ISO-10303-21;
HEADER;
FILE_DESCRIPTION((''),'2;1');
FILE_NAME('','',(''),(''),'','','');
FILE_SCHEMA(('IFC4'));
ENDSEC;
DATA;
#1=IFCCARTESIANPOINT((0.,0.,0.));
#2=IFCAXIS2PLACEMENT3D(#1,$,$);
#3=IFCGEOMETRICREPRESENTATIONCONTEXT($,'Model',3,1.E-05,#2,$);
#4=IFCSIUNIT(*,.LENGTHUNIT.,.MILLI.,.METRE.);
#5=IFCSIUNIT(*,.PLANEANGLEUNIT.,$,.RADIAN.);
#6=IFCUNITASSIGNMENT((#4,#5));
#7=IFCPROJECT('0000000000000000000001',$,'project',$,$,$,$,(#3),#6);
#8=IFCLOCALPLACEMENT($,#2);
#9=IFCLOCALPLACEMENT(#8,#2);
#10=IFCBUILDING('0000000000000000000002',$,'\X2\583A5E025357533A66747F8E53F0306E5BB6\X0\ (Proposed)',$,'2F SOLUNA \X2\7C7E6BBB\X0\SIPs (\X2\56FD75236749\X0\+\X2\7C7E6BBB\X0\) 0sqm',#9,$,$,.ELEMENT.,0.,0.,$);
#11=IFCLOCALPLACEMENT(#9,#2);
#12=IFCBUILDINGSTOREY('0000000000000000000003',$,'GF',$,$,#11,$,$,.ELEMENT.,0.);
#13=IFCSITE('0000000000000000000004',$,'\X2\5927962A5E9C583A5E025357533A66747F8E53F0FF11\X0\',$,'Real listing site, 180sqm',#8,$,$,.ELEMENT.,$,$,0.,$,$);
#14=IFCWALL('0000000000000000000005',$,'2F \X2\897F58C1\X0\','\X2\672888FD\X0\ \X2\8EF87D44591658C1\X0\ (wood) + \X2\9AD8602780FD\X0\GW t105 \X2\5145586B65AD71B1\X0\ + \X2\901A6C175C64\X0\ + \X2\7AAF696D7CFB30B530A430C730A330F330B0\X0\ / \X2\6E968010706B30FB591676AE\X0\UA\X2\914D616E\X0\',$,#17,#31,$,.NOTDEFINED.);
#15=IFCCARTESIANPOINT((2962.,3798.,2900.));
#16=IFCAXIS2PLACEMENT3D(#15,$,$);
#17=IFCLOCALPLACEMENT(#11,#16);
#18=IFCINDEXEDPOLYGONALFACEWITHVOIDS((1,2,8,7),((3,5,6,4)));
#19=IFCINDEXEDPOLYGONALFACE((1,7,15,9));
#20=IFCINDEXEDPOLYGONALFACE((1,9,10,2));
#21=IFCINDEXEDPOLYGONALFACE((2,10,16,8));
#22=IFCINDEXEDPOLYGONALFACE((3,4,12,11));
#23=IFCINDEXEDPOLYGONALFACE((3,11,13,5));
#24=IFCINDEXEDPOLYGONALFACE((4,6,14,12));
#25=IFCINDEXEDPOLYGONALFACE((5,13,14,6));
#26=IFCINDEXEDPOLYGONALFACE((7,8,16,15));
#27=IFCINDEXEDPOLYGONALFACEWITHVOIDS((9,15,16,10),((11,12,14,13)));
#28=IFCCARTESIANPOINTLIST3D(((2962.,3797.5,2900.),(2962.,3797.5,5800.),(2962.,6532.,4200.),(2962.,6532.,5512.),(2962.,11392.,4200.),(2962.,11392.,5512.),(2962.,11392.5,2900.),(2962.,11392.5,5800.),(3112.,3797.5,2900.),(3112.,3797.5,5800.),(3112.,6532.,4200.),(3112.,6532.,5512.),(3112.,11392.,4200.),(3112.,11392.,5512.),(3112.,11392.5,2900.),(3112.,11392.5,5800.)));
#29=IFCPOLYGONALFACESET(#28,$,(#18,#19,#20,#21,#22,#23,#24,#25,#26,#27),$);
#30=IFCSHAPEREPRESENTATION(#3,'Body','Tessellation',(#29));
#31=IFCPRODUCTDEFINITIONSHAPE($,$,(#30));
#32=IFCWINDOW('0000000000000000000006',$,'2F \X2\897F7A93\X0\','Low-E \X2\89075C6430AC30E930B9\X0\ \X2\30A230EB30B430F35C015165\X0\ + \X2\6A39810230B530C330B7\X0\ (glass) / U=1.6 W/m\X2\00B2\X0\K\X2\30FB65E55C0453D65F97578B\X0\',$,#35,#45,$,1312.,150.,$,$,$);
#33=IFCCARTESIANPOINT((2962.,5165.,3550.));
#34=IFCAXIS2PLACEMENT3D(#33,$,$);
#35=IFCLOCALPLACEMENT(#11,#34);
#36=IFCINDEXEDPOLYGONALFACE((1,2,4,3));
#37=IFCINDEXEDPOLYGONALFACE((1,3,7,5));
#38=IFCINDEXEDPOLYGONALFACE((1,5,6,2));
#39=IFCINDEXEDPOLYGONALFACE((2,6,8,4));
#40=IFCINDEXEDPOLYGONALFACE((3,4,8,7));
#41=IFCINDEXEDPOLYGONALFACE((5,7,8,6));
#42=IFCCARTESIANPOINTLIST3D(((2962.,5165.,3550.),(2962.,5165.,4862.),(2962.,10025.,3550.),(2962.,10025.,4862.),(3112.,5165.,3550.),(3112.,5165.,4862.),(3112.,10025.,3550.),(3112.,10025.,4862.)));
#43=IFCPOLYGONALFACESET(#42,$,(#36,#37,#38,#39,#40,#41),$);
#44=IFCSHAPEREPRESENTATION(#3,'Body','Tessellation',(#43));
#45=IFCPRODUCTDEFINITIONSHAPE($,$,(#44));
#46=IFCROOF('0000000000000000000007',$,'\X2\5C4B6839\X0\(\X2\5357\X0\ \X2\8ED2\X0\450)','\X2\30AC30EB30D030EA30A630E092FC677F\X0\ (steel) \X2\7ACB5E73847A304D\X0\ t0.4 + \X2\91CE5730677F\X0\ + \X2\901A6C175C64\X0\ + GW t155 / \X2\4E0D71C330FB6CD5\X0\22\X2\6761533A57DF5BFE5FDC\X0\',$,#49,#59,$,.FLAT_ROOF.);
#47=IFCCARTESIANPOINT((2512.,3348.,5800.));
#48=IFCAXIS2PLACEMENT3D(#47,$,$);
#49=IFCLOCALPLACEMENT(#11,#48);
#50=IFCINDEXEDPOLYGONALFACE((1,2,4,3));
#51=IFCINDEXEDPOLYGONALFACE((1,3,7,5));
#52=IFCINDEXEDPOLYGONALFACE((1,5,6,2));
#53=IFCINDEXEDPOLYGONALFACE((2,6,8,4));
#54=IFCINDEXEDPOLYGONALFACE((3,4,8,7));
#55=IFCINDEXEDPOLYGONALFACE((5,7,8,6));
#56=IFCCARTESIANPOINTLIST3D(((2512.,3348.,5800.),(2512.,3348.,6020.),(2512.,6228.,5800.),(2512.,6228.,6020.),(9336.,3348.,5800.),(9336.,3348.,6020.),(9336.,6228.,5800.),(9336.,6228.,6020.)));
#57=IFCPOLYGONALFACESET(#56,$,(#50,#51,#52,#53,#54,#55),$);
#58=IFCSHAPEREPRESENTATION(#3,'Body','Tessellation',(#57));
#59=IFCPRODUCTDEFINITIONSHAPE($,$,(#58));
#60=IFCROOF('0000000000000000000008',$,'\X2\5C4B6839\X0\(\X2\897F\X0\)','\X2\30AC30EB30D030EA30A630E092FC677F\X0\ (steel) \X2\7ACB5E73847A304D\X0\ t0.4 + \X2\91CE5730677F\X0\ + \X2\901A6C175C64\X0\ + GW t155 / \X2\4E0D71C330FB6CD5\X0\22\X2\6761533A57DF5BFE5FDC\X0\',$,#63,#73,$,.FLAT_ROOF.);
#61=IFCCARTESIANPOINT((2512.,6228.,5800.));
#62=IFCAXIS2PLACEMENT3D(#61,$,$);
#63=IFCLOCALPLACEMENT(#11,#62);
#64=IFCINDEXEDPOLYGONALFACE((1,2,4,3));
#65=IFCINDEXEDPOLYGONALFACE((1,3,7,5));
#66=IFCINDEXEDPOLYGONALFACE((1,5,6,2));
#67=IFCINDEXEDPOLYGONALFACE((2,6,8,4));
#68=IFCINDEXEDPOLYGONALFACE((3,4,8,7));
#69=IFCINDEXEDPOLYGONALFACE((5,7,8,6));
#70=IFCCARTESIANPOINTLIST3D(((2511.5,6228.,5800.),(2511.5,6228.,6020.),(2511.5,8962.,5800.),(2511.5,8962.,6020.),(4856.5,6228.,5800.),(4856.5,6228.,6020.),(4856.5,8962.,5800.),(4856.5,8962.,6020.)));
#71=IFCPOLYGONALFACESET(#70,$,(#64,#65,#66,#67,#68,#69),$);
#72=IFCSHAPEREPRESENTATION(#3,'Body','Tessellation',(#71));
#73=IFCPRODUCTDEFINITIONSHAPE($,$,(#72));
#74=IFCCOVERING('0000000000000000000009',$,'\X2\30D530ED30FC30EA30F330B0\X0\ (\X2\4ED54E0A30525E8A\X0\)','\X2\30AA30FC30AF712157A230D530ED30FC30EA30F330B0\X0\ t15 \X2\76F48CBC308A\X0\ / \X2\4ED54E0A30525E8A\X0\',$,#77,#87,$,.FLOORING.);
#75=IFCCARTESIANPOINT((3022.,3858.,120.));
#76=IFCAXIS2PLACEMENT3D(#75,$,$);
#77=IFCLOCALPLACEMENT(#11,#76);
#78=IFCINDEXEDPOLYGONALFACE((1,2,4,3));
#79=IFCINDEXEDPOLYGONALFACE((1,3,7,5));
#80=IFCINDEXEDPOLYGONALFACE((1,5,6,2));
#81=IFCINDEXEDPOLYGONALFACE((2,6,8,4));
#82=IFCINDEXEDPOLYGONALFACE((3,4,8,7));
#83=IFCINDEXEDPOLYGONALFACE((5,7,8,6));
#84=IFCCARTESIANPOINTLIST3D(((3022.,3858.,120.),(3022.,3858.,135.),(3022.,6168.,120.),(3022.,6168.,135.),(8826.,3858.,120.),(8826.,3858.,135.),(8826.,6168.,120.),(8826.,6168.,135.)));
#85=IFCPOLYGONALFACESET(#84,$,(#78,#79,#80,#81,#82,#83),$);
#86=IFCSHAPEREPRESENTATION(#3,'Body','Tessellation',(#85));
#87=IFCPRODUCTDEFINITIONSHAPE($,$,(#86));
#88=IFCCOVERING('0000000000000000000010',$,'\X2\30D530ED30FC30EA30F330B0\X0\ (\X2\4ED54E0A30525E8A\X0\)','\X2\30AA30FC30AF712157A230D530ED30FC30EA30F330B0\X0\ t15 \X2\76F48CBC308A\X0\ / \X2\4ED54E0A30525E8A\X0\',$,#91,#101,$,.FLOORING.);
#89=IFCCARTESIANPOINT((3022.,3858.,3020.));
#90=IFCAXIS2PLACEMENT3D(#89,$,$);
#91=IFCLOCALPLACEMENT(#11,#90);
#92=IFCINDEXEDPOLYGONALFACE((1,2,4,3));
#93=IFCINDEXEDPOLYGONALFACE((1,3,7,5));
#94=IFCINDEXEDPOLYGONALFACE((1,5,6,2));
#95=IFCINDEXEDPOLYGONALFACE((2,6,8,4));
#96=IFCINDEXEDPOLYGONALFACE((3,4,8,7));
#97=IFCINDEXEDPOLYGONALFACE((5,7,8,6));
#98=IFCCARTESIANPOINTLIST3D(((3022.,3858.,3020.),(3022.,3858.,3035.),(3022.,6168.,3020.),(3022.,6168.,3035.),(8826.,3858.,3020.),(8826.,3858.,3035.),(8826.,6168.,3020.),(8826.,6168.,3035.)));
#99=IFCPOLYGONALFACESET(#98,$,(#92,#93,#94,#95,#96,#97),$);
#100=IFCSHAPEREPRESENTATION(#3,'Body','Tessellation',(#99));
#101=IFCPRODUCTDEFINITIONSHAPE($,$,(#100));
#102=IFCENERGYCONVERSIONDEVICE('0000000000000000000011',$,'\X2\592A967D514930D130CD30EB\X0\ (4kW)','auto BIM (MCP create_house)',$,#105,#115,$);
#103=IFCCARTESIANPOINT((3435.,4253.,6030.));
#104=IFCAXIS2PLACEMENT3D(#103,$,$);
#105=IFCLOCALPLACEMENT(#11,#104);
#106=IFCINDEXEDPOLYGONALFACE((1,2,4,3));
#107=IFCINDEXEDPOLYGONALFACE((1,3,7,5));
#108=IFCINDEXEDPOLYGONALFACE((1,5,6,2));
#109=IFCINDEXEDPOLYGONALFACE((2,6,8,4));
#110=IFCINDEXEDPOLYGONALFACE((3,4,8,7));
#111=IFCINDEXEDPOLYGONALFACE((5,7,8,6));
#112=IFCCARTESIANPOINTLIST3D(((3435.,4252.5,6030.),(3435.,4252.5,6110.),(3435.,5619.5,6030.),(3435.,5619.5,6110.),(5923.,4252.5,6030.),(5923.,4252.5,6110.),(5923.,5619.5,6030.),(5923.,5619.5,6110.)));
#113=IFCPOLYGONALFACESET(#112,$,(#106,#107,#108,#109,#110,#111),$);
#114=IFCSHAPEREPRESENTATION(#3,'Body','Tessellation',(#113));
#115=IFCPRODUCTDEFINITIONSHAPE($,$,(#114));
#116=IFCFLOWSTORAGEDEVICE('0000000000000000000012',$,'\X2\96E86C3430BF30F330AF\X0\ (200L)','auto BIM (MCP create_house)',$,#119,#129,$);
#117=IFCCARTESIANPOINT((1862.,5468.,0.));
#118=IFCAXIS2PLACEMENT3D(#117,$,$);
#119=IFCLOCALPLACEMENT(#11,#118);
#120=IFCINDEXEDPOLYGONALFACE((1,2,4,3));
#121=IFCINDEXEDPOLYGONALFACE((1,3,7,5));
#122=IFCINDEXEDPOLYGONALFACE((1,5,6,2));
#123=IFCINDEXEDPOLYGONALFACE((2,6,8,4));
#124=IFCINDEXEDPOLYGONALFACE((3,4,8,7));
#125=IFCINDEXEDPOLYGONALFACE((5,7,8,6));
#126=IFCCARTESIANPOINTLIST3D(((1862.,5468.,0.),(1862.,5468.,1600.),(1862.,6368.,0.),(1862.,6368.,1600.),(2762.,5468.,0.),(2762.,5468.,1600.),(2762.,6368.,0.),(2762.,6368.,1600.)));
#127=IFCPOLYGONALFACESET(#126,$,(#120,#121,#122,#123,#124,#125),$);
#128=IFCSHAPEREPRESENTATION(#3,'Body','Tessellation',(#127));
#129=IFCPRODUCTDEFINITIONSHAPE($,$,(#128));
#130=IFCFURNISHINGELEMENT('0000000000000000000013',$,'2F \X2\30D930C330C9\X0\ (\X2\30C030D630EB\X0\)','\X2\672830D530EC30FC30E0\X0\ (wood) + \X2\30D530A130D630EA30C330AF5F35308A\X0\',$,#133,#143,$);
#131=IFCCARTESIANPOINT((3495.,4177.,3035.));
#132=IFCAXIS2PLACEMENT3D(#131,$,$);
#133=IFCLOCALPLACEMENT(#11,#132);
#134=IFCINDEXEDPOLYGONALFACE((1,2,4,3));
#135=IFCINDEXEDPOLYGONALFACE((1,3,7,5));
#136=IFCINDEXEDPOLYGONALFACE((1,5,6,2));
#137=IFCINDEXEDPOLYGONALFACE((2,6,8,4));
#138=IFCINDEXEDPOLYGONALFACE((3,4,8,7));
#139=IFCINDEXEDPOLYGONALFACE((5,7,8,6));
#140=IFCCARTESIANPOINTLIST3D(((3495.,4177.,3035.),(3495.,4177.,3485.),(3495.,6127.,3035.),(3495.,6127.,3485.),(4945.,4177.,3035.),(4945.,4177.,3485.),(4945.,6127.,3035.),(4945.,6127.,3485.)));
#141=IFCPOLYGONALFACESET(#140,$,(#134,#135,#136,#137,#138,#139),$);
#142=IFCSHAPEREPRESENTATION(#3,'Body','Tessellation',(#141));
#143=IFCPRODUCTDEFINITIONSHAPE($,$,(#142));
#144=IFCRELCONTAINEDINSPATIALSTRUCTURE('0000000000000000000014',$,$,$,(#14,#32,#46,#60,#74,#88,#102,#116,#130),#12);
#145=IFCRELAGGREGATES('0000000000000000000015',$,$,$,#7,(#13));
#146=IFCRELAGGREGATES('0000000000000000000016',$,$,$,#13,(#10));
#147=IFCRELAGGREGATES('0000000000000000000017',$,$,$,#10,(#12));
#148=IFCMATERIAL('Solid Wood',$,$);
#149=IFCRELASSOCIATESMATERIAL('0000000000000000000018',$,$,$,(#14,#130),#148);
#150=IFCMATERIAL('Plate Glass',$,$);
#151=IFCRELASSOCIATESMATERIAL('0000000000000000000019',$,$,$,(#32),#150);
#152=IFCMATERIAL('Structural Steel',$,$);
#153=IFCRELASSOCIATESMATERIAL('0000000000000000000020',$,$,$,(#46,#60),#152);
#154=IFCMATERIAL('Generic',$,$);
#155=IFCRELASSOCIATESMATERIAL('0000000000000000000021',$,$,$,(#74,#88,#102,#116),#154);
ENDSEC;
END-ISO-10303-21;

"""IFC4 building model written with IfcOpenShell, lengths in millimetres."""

from ifc_helpers import new_model, si_unit, frame, frame_2d, origin, place, context, project, spatial, rectangle, extrude, material, element, fill, save


model = new_model("IFC4")

# Units and contexts
model_context = context("Model", 3, precision=1e-05, world=origin())
ifc_project = project(units=[si_unit("LENGTHUNIT", "METRE", prefix="MILLI"), si_unit("PLANEANGLEUNIT", "RADIAN")], contexts=[model_context])

# Site, building, storey
site_placement = place(None, origin())
site = spatial("IfcSite", under=ifc_project, at=site_placement, Name="大阪府堺市南区晴美台１", ObjectType="Real listing site, 180sqm", CompositionType="ELEMENT", RefElevation=0.0)
building_placement = place(site_placement, origin())
building = spatial("IfcBuilding", under=site, at=building_placement, Name="堺市南区晴美台の家 (Proposed)", ObjectType="2F SOLUNA 籾殻SIPs (国産杉+籾殻) 0sqm", CompositionType="ELEMENT", ElevationOfRefHeight=0.0, ElevationOfTerrain=0.0)
storey_placement = place(building_placement, origin())
storey = spatial("IfcBuildingStorey", under=building, at=storey_placement, Name="GF", CompositionType="ELEMENT", Elevation=0.0)

# Shared definitions
ifc_material_1 = material(Name="Solid Wood")

# Shared definitions
ifc_material_2 = material(Name="Plate Glass")

# Wall, opening, window
wall_1_placement = place(storey_placement, frame((2962.0, 3798.0, 2900.0)))
wall_1 = element("IfcWall", 1, at=wall_1_placement, inside=storey, material=ifc_material_1, Name="2F 西壁", Description="木製 軸組外壁 (wood) + 高性能GW t105 充填断熱 + 通気層 + 窯業系サイディング / 準耐火・外皮UA配慮", PredefinedType="NOTDEFINED", context=model_context, shape_type="SweptSolid", body=[
    extrude(rectangle(XDim=150.0, YDim=7595.0, at=frame_2d((75.0, 3797.0))), frame((2962.0, 3798.0, 2900.0)), (0.0, 0.0, 1.0), 2900.0),
])
opening_1_placement = place(storey_placement, frame((2962.0, 5165.0, 3550.0)))
opening_1 = element("IfcOpeningElement", 2, at=opening_1_placement, cuts=wall_1, PredefinedType="NOTDEFINED", context=model_context, shape_type="SweptSolid", body=[
    extrude(rectangle(XDim=150.0, YDim=4860.0, at=frame_2d((75.0, 2430.0))), frame((2962.0, 5165.0, 3550.0)), (0.0, 0.0, 1.0), 1312.0),
])
window_1_placement = place(storey_placement, frame((2962.0, 5165.0, 3550.0)))
window_1 = element("IfcWindow", 3, at=window_1_placement, inside=storey, material=ifc_material_2, Name="2F 西窓", Description="Low-E 複層ガラス アルゴン封入 + 樹脂サッシ (glass) / U=1.6 W/m²K・日射取得型", OverallHeight=1312.0, OverallWidth=150.0, context=model_context, shape_type="SweptSolid", body=[
    extrude(rectangle(XDim=150.0, YDim=4860.0, at=frame_2d((75.0, 2430.0))), frame((2962.0, 5165.0, 3550.0)), (0.0, 0.0, 1.0), 1312.0),
])
fill(opening_1, window_1)

# Roofs
ifc_material_3 = material(Name="Structural Steel")
roof_1_placement = place(storey_placement, frame((2512.0, 3348.0, 5800.0)))
element("IfcRoof", 4, at=roof_1_placement, inside=storey, material=ifc_material_3, Name="屋根(南 軒450)", Description="ガルバリウム鋼板 (steel) 立平葺き t0.4 + 野地板 + 通気層 + GW t155 / 不燃・法22条区域対応", PredefinedType="FLAT_ROOF", context=model_context, shape_type="SweptSolid", body=[
    extrude(rectangle(XDim=6824.0, YDim=2880.0, at=frame_2d((3412.0, 1440.0))), frame((2512.0, 3348.0, 5800.0)), (0.0, 0.0, 1.0), 220.0),
])
roof_2_placement = place(storey_placement, frame((2512.0, 6228.0, 5800.0)))
element("IfcRoof", 5, at=roof_2_placement, inside=storey, material=ifc_material_3, Name="屋根(西)", Description="ガルバリウム鋼板 (steel) 立平葺き t0.4 + 野地板 + 通気層 + GW t155 / 不燃・法22条区域対応", PredefinedType="FLAT_ROOF", context=model_context, shape_type="SweptSolid", body=[
    extrude(rectangle(XDim=2345.0, YDim=2734.0, at=frame_2d((1172.0, 1367.0))), frame((2512.0, 6228.0, 5800.0)), (0.0, 0.0, 1.0), 220.0),
])

# Coverings
ifc_material_4 = material(Name="Generic")
covering_1_placement = place(storey_placement, frame((3022.0, 3858.0, 120.0)))
element("IfcCovering", 6, at=covering_1_placement, inside=storey, material=ifc_material_4, Name="フローリング (仕上げ床)", Description="オーク無垢フローリング t15 直貼り / 仕上げ床", PredefinedType="FLOORING", context=model_context, shape_type="SweptSolid", body=[
    extrude(rectangle(XDim=5804.0, YDim=2310.0, at=frame_2d((2902.0, 1155.0))), frame((3022.0, 3858.0, 120.0)), (0.0, 0.0, 1.0), 15.0),
])
covering_2_placement = place(storey_placement, frame((3022.0, 3858.0, 3020.0)))
element("IfcCovering", 7, at=covering_2_placement, inside=storey, material=ifc_material_4, Name="フローリング (仕上げ床)", Description="オーク無垢フローリング t15 直貼り / 仕上げ床", PredefinedType="FLOORING", context=model_context, shape_type="SweptSolid", body=[
    extrude(rectangle(XDim=5804.0, YDim=2310.0, at=frame_2d((2902.0, 1155.0))), frame((3022.0, 3858.0, 3020.0)), (0.0, 0.0, 1.0), 15.0),
])

# Energy conversion device
energy_conversion_device_placement = place(storey_placement, frame((3435.0, 4253.0, 6030.0)))
element("IfcEnergyConversionDevice", 8, at=energy_conversion_device_placement, inside=storey, material=ifc_material_4, Name="太陽光パネル (4kW)", Description="auto BIM (MCP create_house)", context=model_context, shape_type="SweptSolid", body=[
    extrude(rectangle(XDim=2488.0, YDim=1367.0, at=frame_2d((1244.0, 683.0))), frame((3435.0, 4253.0, 6030.0)), (0.0, 0.0, 1.0), 80.0),
])

# Flow storage device
flow_storage_device_placement = place(storey_placement, frame((1862.0, 5468.0, 0.0)))
element("IfcFlowStorageDevice", 9, at=flow_storage_device_placement, inside=storey, material=ifc_material_4, Name="雨水タンク (200L)", Description="auto BIM (MCP create_house)", context=model_context, shape_type="SweptSolid", body=[
    extrude(rectangle(XDim=900.0, YDim=900.0, at=frame_2d((450.0, 450.0))), frame((1862.0, 5468.0, 0.0)), (0.0, 0.0, 1.0), 1600.0),
])

# Furnishing element
furnishing_placement = place(storey_placement, frame((3495.0, 4177.0, 3035.0)))
element("IfcFurnishingElement", 10, at=furnishing_placement, inside=storey, material=ifc_material_1, Name="2F ベッド (ダブル)", Description="木フレーム (wood) + ファブリック張り", context=model_context, shape_type="SweptSolid", body=[
    extrude(rectangle(XDim=1450.0, YDim=1950.0, at=frame_2d((725.0, 975.0))), frame((3495.0, 4177.0, 3035.0)), (0.0, 0.0, 1.0), 450.0),
])

save(model, "model.ifc")
